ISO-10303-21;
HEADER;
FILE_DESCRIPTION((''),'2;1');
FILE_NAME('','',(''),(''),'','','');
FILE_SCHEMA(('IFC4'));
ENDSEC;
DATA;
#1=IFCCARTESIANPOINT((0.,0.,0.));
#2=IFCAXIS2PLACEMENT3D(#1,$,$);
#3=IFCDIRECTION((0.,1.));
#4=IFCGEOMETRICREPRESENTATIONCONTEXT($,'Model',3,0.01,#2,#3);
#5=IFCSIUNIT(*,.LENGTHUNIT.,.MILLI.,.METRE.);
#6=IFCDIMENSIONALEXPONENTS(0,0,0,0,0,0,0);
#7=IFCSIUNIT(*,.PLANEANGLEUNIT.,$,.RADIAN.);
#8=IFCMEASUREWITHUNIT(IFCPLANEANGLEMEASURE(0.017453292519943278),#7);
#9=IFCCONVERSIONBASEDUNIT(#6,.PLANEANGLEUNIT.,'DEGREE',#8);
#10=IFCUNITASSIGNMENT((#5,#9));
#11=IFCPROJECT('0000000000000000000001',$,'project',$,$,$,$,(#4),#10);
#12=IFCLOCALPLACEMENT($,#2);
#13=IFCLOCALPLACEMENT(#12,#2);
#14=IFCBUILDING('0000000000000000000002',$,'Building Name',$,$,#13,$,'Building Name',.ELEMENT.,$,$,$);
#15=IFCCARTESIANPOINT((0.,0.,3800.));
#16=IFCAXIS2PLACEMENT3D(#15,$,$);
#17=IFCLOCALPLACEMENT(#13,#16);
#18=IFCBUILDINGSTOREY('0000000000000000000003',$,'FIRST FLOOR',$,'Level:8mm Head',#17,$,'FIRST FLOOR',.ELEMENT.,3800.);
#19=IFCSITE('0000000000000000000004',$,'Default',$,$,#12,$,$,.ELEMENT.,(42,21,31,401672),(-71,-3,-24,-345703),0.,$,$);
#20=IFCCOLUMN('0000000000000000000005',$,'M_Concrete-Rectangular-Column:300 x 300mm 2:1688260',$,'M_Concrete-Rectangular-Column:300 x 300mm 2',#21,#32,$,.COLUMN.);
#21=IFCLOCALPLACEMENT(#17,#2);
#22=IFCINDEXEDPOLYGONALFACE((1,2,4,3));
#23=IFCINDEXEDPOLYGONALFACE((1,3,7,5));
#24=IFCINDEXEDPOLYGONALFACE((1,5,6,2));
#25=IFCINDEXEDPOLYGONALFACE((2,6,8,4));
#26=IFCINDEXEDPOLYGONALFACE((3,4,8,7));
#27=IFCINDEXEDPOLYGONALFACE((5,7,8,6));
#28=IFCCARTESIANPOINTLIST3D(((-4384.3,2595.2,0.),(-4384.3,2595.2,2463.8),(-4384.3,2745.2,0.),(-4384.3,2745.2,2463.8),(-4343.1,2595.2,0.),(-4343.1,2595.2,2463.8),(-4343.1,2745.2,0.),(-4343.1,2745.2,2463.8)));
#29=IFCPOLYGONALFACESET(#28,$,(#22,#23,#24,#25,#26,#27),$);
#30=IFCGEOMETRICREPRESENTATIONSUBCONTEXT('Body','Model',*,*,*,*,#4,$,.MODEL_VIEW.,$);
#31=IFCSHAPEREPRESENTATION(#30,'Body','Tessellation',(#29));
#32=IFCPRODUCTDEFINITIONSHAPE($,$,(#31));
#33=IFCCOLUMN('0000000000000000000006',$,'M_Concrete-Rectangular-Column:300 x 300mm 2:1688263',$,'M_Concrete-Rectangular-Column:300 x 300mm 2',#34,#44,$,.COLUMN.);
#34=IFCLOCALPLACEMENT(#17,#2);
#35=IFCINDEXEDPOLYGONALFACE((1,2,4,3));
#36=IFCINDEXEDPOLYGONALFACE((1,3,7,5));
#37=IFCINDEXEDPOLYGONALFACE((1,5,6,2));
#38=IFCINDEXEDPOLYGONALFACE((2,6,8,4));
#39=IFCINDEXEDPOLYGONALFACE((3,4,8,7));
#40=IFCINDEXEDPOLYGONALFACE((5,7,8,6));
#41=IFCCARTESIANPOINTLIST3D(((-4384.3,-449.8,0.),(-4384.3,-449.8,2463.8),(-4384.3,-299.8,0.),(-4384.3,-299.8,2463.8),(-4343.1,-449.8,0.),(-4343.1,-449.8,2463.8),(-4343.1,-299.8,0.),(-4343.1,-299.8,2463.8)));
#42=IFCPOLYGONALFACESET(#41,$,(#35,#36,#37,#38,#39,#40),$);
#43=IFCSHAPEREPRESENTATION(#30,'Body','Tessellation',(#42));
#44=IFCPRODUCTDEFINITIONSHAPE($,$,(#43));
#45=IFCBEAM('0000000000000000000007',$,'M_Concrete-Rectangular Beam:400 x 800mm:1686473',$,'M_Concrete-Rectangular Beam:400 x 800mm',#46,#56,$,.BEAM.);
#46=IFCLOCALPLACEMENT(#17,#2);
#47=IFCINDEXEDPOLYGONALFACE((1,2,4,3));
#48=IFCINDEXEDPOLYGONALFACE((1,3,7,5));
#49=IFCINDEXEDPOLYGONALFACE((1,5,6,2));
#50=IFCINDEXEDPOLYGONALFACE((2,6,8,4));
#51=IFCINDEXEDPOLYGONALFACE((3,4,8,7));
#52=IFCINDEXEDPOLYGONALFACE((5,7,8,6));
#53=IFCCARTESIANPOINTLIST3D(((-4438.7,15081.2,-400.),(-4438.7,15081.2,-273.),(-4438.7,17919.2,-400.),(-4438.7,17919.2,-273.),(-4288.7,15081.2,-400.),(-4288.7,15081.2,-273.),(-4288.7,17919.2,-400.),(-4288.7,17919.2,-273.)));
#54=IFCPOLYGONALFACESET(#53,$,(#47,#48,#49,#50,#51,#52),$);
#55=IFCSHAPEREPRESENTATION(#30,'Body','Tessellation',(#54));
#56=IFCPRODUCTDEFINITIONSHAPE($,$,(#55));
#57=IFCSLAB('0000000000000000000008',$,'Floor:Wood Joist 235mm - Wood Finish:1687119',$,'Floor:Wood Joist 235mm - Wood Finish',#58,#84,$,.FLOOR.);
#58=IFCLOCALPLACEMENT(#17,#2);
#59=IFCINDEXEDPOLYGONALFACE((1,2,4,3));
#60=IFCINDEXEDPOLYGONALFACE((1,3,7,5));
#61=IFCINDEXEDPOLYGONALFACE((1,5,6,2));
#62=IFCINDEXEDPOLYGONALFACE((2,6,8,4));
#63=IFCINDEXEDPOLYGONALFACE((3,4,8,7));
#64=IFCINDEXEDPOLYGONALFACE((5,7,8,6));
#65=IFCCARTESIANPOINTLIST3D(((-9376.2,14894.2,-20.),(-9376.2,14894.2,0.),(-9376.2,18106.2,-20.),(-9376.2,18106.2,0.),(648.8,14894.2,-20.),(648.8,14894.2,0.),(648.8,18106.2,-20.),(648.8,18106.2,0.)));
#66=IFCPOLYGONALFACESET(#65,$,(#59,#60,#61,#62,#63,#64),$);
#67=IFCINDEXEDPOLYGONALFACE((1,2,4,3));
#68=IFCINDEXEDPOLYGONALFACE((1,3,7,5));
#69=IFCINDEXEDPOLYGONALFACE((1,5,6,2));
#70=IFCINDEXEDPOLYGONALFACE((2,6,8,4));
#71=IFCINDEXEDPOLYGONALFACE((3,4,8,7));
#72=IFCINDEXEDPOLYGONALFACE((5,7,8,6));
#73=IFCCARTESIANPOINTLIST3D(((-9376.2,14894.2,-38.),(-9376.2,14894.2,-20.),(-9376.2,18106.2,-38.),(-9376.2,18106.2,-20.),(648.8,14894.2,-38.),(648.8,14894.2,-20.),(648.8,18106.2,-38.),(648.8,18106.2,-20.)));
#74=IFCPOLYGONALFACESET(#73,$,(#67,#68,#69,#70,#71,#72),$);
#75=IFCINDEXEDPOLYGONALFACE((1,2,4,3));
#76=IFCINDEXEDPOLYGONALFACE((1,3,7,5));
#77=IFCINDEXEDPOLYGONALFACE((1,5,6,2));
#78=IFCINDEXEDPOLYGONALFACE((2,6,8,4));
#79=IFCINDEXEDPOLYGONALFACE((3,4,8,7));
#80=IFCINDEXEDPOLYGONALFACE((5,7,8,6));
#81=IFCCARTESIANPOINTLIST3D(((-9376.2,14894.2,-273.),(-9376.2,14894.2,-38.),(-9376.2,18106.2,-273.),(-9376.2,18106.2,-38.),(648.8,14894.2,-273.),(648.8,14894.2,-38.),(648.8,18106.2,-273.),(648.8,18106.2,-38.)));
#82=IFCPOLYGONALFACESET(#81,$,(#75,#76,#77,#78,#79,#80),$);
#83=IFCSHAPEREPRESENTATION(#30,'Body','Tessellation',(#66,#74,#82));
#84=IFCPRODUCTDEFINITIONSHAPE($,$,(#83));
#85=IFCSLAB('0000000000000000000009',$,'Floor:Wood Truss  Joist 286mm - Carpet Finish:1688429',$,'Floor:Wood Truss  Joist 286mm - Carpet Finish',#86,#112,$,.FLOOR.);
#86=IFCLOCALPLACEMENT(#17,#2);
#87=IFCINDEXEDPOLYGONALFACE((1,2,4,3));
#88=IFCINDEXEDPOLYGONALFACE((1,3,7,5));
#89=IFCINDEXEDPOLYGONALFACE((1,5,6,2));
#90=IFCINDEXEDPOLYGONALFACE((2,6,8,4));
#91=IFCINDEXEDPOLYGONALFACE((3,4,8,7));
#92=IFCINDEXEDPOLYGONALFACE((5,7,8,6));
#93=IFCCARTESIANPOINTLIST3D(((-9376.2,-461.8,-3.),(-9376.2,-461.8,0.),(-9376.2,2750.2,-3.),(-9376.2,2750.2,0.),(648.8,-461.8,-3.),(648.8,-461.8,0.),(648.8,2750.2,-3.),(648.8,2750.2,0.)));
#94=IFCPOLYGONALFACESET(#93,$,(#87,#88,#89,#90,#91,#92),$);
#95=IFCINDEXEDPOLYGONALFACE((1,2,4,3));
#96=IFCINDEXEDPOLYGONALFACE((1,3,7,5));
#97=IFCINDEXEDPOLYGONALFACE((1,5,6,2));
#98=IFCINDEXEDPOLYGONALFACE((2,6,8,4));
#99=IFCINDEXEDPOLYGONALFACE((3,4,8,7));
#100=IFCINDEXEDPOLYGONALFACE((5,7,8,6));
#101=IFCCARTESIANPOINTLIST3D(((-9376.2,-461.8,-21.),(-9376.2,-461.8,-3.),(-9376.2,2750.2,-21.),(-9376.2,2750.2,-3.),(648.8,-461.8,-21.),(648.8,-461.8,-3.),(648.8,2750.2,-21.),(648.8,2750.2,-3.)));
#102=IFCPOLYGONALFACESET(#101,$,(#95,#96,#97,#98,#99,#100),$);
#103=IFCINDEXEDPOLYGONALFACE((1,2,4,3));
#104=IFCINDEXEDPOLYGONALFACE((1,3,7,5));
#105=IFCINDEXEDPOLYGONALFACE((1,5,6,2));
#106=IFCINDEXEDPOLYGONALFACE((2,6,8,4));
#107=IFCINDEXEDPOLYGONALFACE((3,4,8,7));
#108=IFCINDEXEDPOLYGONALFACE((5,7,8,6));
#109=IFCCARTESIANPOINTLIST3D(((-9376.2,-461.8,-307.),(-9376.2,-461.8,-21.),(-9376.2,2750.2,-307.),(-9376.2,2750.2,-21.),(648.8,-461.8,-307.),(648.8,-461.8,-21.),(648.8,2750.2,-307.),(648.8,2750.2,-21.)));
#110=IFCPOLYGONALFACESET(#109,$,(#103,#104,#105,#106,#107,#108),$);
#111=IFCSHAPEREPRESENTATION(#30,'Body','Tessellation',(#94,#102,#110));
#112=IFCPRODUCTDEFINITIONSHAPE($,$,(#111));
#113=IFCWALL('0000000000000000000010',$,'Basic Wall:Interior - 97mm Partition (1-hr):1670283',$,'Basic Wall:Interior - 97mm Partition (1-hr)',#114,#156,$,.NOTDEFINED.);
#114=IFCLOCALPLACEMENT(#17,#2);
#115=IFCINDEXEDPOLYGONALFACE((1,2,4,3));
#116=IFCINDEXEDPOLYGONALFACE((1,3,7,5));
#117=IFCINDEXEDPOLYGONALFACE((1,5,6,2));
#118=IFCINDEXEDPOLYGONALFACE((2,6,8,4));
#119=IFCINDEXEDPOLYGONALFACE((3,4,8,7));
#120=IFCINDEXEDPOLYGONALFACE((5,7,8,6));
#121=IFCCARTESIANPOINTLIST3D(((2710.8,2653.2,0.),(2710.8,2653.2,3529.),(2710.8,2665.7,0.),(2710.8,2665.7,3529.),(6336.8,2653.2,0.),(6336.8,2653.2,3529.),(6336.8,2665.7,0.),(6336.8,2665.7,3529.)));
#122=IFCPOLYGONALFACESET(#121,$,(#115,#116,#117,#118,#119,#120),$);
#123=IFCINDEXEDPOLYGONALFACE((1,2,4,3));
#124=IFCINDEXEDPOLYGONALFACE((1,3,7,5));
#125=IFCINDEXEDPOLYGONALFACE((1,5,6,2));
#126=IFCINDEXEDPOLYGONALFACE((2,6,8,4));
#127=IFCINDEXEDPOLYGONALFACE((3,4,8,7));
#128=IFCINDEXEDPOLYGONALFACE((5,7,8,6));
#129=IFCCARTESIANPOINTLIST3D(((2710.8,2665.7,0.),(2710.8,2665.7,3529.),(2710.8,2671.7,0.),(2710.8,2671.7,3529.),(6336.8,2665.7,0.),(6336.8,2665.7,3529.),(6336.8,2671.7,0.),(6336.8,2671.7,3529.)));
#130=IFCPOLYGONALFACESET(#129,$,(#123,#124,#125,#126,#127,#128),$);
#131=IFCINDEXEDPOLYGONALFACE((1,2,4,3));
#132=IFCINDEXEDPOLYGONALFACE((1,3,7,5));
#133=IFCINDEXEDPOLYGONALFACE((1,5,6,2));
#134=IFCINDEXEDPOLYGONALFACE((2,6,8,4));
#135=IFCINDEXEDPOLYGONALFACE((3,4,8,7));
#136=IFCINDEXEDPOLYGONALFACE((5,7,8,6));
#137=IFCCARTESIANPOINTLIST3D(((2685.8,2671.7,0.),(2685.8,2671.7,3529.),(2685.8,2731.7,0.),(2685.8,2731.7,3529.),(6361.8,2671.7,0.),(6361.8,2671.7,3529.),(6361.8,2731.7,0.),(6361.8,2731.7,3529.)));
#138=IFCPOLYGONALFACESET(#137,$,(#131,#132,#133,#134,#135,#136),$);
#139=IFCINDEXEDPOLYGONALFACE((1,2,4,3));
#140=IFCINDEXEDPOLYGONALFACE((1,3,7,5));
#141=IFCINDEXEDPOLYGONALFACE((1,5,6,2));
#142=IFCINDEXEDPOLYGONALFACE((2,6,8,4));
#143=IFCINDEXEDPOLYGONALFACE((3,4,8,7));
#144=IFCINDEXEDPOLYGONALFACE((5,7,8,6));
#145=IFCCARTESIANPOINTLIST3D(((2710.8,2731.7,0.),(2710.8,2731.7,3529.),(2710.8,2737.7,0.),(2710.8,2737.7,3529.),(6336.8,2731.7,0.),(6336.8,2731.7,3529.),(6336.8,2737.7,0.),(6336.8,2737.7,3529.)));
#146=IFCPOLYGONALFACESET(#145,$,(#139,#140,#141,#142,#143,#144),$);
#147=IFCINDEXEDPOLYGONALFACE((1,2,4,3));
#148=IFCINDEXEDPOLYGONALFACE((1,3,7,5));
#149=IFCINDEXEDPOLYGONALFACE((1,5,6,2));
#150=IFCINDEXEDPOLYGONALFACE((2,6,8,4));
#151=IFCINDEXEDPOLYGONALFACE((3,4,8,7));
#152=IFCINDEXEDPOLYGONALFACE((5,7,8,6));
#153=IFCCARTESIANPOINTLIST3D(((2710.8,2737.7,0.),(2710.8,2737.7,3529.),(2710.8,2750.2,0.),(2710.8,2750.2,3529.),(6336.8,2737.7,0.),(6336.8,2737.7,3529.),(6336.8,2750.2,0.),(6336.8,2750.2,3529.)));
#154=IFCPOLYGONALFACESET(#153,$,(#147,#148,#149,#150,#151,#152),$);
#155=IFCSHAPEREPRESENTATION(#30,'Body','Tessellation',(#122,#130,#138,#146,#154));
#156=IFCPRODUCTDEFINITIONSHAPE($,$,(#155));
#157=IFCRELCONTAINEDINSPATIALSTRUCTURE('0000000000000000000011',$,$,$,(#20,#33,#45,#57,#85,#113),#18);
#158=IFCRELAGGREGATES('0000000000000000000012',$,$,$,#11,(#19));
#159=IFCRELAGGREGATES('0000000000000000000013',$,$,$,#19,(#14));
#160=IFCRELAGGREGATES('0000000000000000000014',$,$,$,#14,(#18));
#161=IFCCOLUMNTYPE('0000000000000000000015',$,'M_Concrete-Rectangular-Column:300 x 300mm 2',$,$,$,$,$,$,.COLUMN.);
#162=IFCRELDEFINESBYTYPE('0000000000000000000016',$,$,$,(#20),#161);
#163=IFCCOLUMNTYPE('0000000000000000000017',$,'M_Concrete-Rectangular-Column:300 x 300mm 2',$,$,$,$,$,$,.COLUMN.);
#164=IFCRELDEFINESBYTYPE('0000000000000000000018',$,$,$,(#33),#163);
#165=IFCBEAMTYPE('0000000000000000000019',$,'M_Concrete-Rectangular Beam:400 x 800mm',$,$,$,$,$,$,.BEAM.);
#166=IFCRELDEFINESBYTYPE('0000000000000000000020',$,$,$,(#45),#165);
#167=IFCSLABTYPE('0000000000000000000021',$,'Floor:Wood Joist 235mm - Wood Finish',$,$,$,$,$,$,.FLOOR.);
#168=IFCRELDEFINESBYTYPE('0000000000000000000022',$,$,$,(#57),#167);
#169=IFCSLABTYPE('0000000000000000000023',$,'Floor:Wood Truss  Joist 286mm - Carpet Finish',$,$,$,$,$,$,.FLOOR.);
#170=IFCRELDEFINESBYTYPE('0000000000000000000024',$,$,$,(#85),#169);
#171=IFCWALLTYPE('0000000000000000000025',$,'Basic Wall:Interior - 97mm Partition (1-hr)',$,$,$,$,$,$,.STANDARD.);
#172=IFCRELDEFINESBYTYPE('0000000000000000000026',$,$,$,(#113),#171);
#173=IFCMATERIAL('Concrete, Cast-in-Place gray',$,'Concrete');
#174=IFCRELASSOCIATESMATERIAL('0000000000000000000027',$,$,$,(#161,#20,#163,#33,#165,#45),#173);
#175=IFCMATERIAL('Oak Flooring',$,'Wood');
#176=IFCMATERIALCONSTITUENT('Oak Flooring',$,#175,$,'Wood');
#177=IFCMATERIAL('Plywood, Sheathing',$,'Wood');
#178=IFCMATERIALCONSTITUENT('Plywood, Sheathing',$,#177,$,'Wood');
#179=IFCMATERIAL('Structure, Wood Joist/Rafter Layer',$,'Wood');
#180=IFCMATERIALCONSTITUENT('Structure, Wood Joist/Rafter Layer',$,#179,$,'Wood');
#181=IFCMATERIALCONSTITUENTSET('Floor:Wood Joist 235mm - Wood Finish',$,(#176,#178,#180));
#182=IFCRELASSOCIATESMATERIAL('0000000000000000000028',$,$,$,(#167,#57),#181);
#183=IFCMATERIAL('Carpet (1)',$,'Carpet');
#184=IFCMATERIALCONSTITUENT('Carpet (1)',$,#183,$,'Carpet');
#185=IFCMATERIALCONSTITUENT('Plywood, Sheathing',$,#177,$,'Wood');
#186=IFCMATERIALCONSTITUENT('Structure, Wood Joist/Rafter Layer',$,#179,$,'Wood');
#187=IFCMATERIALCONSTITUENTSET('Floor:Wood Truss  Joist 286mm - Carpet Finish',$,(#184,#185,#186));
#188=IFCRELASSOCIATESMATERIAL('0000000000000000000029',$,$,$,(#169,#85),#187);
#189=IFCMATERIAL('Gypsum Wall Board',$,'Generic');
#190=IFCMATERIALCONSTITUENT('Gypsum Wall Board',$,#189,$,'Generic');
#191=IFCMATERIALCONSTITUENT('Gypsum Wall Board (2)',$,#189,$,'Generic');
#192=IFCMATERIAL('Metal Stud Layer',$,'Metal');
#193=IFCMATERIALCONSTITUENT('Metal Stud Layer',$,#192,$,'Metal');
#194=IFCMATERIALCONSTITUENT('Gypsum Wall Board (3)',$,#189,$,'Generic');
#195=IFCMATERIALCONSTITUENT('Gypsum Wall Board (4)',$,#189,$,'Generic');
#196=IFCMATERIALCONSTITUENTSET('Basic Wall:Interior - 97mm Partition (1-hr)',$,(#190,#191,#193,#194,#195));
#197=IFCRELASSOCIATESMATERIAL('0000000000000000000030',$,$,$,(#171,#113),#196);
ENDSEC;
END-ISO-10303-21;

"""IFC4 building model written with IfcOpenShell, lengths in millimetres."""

from ifc_helpers import new_model, entity, si_unit, converted_unit, direction, frame, origin, place, context, subcontext, project, spatial, indexed_curve, outline, extrude, source, transform, mapped, material, constituent, constituent_set, type_object, type_shapes, element, save


model = new_model("IFC4")

# Units and contexts
model_context = context("Model", 3, precision=0.01, world=origin(), true_north=direction((0.0, 1.0)))
body_context = subcontext(model_context, "Body", "Model", "MODEL_VIEW")
ifc_project = project(units=[si_unit("LENGTHUNIT", "METRE", prefix="MILLI"), converted_unit("PLANEANGLEUNIT", "DEGREE", entity("IfcPlaneAngleMeasure", 0.017453292519943278), si_unit("PLANEANGLEUNIT", "RADIAN"), dimensions=[0, 0, 0, 0, 0, 0, 0])], contexts=[model_context])

# Site, building, storey
site_placement = place(None, origin())
site = spatial("IfcSite", under=ifc_project, at=site_placement, Name="Default", CompositionType="ELEMENT", RefLatitude=(42, 21, 31, 401672), RefLongitude=(-71, -3, -24, -345703), RefElevation=0.0)
building_placement = place(site_placement, origin())
building = spatial("IfcBuilding", under=site, at=building_placement, Name="Building Name", LongName="Building Name", CompositionType="ELEMENT")
storey_placement = place(building_placement, frame((0.0, 0.0, 3800.0)))
storey = spatial("IfcBuildingStorey", under=building, at=storey_placement, Name="FIRST FLOOR", ObjectType="Level:8mm Head", LongName="FIRST FLOOR", CompositionType="ELEMENT", Elevation=3800.0)

# Columns
ifc_material_1 = material(Name="Concrete, Cast-in-Place gray", Category="Concrete")
column_type_1 = type_object("IfcColumnType", Name="M_Concrete-Rectangular-Column:300 x 300mm 2", PredefinedType="COLUMN", material=ifc_material_1)
shared_shape_1 = source(origin(), body_context, "Body", "SweptSolid", [
    extrude(outline(indexed_curve([(-1231.9, -75.0), (1231.9, -75.0), (1231.9, 75.0), (-1231.9, 75.0), (-1231.9, -75.0)], self_intersect=False)), frame((-4384.3, 2670.2, 5031.9), z_axis=(1.0, 0.0, 0.0), x_axis=(0.0, 0.0, -1.0)), (0.0, 0.0, 1.0), 41.3),
])
type_shapes(column_type_1, [shared_shape_1])
column_1_placement = place(storey_placement, frame((0.0, 0.0, -3800.0)))
element("IfcColumn", 1, at=column_1_placement, inside=storey, type_object=column_type_1, material=ifc_material_1, Name="M_Concrete-Rectangular-Column:300 x 300mm 2:1688260", ObjectType="M_Concrete-Rectangular-Column:300 x 300mm 2", PredefinedType="COLUMN", context=body_context, shape_type="MappedRepresentation", body=[
    mapped(shared_shape_1, transform((0.0, 0.0, 0.0), scale=1.0)),
])
column_type_2 = type_object("IfcColumnType", Name="M_Concrete-Rectangular-Column:300 x 300mm 2", PredefinedType="COLUMN", material=ifc_material_1)
shared_shape_2 = source(origin(), body_context, "Body", "SweptSolid", [
    extrude(outline(indexed_curve([(-1231.9, -75.0), (1231.9, -75.0), (1231.9, 75.0), (-1231.9, 75.0), (-1231.9, -75.0)], self_intersect=False)), frame((-4384.3, -374.8, 5031.9), z_axis=(1.0, 0.0, 0.0), x_axis=(0.0, 0.0, -1.0)), (0.0, 0.0, 1.0), 41.3),
])
type_shapes(column_type_2, [shared_shape_2])
column_2_placement = place(storey_placement, frame((0.0, 0.0, -3800.0)))
element("IfcColumn", 2, at=column_2_placement, inside=storey, type_object=column_type_2, material=ifc_material_1, Name="M_Concrete-Rectangular-Column:300 x 300mm 2:1688263", ObjectType="M_Concrete-Rectangular-Column:300 x 300mm 2", PredefinedType="COLUMN", context=body_context, shape_type="MappedRepresentation", body=[
    mapped(shared_shape_2, transform((0.0, 0.0, 0.0), scale=1.0)),
])

# Beam
beam_type = type_object("IfcBeamType", Name="M_Concrete-Rectangular Beam:400 x 800mm", PredefinedType="BEAM", material=ifc_material_1)
shared_shape_3 = source(origin(), body_context, "Body", "SweptSolid", [
    extrude(outline(indexed_curve([(-75.0, -63.5), (75.0, -63.5), (75.0, 63.5), (-75.0, 63.5), (-75.0, -63.5)], self_intersect=False)), frame((-4363.7, 15081.2, 3463.5), z_axis=(0.0, 1.0, 0.0), x_axis=(-1.0, 0.0, 0.0)), (0.0, 0.0, 1.0), 2838.0),
])
type_shapes(beam_type, [shared_shape_3])
beam_placement = place(storey_placement, frame((0.0, 0.0, -3800.0)))
element("IfcBeam", 3, at=beam_placement, inside=storey, type_object=beam_type, material=ifc_material_1, Name="M_Concrete-Rectangular Beam:400 x 800mm:1686473", ObjectType="M_Concrete-Rectangular Beam:400 x 800mm", PredefinedType="BEAM", context=body_context, shape_type="MappedRepresentation", body=[
    mapped(shared_shape_3, transform((0.0, 0.0, 0.0), scale=1.0)),
])

# Slabs
ifc_material_2 = material(Name="Oak Flooring", Category="Wood")
ifc_constituent_1 = constituent(ifc_material_2, Name="Oak Flooring", Category="Wood")
ifc_material_3 = material(Name="Plywood, Sheathing", Category="Wood")
ifc_constituent_2 = constituent(ifc_material_3, Name="Plywood, Sheathing", Category="Wood")
ifc_material_4 = material(Name="Structure, Wood Joist/Rafter Layer", Category="Wood")
ifc_constituent_3 = constituent(ifc_material_4, Name="Structure, Wood Joist/Rafter Layer", Category="Wood")
ifc_constituent_set_1 = constituent_set(constituents=[ifc_constituent_1, ifc_constituent_2, ifc_constituent_3], Name="Floor:Wood Joist 235mm - Wood Finish")
slab_type_1 = type_object("IfcSlabType", Name="Floor:Wood Joist 235mm - Wood Finish", PredefinedType="FLOOR", material=ifc_constituent_set_1)
slab_1_placement = place(storey_placement, origin())
element("IfcSlab", 4, at=slab_1_placement, inside=storey, type_object=slab_type_1, material=ifc_constituent_set_1, Name="Floor:Wood Joist 235mm - Wood Finish:1687119", ObjectType="Floor:Wood Joist 235mm - Wood Finish", PredefinedType="FLOOR", context=body_context, shape_type="SweptSolid", body=[
    extrude(outline(indexed_curve([(-5012.5, -1606.0), (5012.5, -1606.0), (5012.5, 1606.0), (-5012.5, 1606.0), (-5012.5, -1606.0)], self_intersect=False)), frame((-4363.7, 16500.2, -20.0), z_axis=(0.0, 0.0, 1.0), x_axis=(-1.0, 0.0, 0.0)), (0.0, 0.0, 1.0), 20.0),
    extrude(outline(indexed_curve([(-5012.5, -1606.0), (5012.5, -1606.0), (5012.5, 1606.0), (-5012.5, 1606.0), (-5012.5, -1606.0)], self_intersect=False)), frame((-4363.7, 16500.2, -38.0), z_axis=(0.0, 0.0, 1.0), x_axis=(-1.0, 0.0, 0.0)), (0.0, 0.0, 1.0), 18.0),
    extrude(outline(indexed_curve([(-5012.5, -1606.0), (5012.5, -1606.0), (5012.5, 1606.0), (-5012.5, 1606.0), (-5012.5, -1606.0)], self_intersect=False)), frame((-4363.7, 16500.2, -273.0), z_axis=(0.0, 0.0, 1.0), x_axis=(-1.0, 0.0, 0.0)), (0.0, 0.0, 1.0), 235.0),
])
ifc_material_5 = material(Name="Carpet (1)", Category="Carpet")
ifc_constituent_4 = constituent(ifc_material_5, Name="Carpet (1)", Category="Carpet")
ifc_constituent_5 = constituent(ifc_material_3, Name="Plywood, Sheathing", Category="Wood")
ifc_constituent_6 = constituent(ifc_material_4, Name="Structure, Wood Joist/Rafter Layer", Category="Wood")
ifc_constituent_set_2 = constituent_set(constituents=[ifc_constituent_4, ifc_constituent_5, ifc_constituent_6], Name="Floor:Wood Truss  Joist 286mm - Carpet Finish")
slab_type_2 = type_object("IfcSlabType", Name="Floor:Wood Truss  Joist 286mm - Carpet Finish", PredefinedType="FLOOR", material=ifc_constituent_set_2)
slab_2_placement = place(storey_placement, origin())
element("IfcSlab", 5, at=slab_2_placement, inside=storey, type_object=slab_type_2, material=ifc_constituent_set_2, Name="Floor:Wood Truss  Joist 286mm - Carpet Finish:1688429", ObjectType="Floor:Wood Truss  Joist 286mm - Carpet Finish", PredefinedType="FLOOR", context=body_context, shape_type="SweptSolid", body=[
    extrude(outline(indexed_curve([(-5012.5, -1606.0), (5012.5, -1606.0), (5012.5, 1606.0), (-5012.5, 1606.0), (-5012.5, -1606.0)], self_intersect=False)), frame((-4363.7, 1144.2, -3.0), z_axis=(0.0, 0.0, 1.0), x_axis=(-1.0, 0.0, 0.0)), (0.0, 0.0, 1.0), 3.0),
    extrude(outline(indexed_curve([(-5012.5, -1606.0), (5012.5, -1606.0), (5012.5, 1606.0), (-5012.5, 1606.0), (-5012.5, -1606.0)], self_intersect=False)), frame((-4363.7, 1144.2, -21.0), z_axis=(0.0, 0.0, 1.0), x_axis=(-1.0, 0.0, 0.0)), (0.0, 0.0, 1.0), 18.0),
    extrude(outline(indexed_curve([(-5012.5, -1606.0), (5012.5, -1606.0), (5012.5, 1606.0), (-5012.5, 1606.0), (-5012.5, -1606.0)], self_intersect=False)), frame((-4363.7, 1144.2, -307.0), z_axis=(0.0, 0.0, 1.0), x_axis=(-1.0, 0.0, 0.0)), (0.0, 0.0, 1.0), 286.0),
])

# Wall
ifc_material_6 = material(Name="Gypsum Wall Board", Category="Generic")
ifc_constituent_7 = constituent(ifc_material_6, Name="Gypsum Wall Board", Category="Generic")
ifc_constituent_8 = constituent(ifc_material_6, Name="Gypsum Wall Board (2)", Category="Generic")
ifc_material_7 = material(Name="Metal Stud Layer", Category="Metal")
ifc_constituent_9 = constituent(ifc_material_7, Name="Metal Stud Layer", Category="Metal")
ifc_constituent_10 = constituent(ifc_material_6, Name="Gypsum Wall Board (3)", Category="Generic")
ifc_constituent_11 = constituent(ifc_material_6, Name="Gypsum Wall Board (4)", Category="Generic")
ifc_constituent_set_3 = constituent_set(constituents=[ifc_constituent_7, ifc_constituent_8, ifc_constituent_9, ifc_constituent_10, ifc_constituent_11], Name="Basic Wall:Interior - 97mm Partition (1-hr)")
wall_type = type_object("IfcWallType", Name="Basic Wall:Interior - 97mm Partition (1-hr)", PredefinedType="STANDARD", material=ifc_constituent_set_3)
wall_1_placement = place(storey_placement, frame((6336.8, 2701.7, 0.0), z_axis=(0.0, 0.0, 1.0), x_axis=(-1.0, 0.0, 0.0)))
element("IfcWall", 6, at=wall_1_placement, inside=storey, type_object=wall_type, material=ifc_constituent_set_3, Name="Basic Wall:Interior - 97mm Partition (1-hr):1670283", ObjectType="Basic Wall:Interior - 97mm Partition (1-hr)", PredefinedType="NOTDEFINED", context=body_context, shape_type="SweptSolid", body=[
    extrude(outline(indexed_curve([(-6.2, -1764.5), (6.3, -1764.5), (6.2, 1764.5), (-6.2, 1764.5), (-6.2, -1764.5)], self_intersect=False)), frame((3626.0, 42.2, 1764.5), z_axis=(-1.0, 0.0, 0.0), x_axis=(0.0, -1.0, 0.0)), (0.0, 0.0, 1.0), 3626.0),
    extrude(outline(indexed_curve([(-1764.5, -3.0), (1764.5, -3.0), (1764.5, 3.0), (-1764.5, 3.0), (-1764.5, -3.0)], self_intersect=False)), frame((3626.0, 33.0, 1764.5), z_axis=(-1.0, 0.0, 0.0), x_axis=(0.0, 0.0, 1.0)), (0.0, 0.0, 1.0), 3626.0),
    extrude(outline(indexed_curve([(-1764.5, -30.0), (1764.5, -30.0), (1764.5, 30.0), (-1764.5, 30.0), (-1764.5, -30.0)], self_intersect=False)), frame((3651.0, 0.0, 1764.5), z_axis=(-1.0, 0.0, 0.0), x_axis=(0.0, 0.0, 1.0)), (0.0, 0.0, 1.0), 3676.0),
    extrude(outline(indexed_curve([(-1764.5, -3.0), (1764.5, -3.0), (1764.5, 3.0), (-1764.5, 3.0), (-1764.5, -3.0)], self_intersect=False)), frame((3626.0, -33.0, 1764.5), z_axis=(-1.0, 0.0, 0.0), x_axis=(0.0, 0.0, 1.0)), (0.0, 0.0, 1.0), 3626.0),
    extrude(outline(indexed_curve([(-6.3, -1764.5), (6.3, -1764.5), (6.3, 1764.5), (-6.3, 1764.5), (-6.3, -1764.5)], self_intersect=False)), frame((3626.0, -42.3, 1764.5), z_axis=(-1.0, 0.0, 0.0), x_axis=(0.0, 1.0, 0.0)), (0.0, 0.0, 1.0), 3626.0),
])

save(model, "model.ifc")
